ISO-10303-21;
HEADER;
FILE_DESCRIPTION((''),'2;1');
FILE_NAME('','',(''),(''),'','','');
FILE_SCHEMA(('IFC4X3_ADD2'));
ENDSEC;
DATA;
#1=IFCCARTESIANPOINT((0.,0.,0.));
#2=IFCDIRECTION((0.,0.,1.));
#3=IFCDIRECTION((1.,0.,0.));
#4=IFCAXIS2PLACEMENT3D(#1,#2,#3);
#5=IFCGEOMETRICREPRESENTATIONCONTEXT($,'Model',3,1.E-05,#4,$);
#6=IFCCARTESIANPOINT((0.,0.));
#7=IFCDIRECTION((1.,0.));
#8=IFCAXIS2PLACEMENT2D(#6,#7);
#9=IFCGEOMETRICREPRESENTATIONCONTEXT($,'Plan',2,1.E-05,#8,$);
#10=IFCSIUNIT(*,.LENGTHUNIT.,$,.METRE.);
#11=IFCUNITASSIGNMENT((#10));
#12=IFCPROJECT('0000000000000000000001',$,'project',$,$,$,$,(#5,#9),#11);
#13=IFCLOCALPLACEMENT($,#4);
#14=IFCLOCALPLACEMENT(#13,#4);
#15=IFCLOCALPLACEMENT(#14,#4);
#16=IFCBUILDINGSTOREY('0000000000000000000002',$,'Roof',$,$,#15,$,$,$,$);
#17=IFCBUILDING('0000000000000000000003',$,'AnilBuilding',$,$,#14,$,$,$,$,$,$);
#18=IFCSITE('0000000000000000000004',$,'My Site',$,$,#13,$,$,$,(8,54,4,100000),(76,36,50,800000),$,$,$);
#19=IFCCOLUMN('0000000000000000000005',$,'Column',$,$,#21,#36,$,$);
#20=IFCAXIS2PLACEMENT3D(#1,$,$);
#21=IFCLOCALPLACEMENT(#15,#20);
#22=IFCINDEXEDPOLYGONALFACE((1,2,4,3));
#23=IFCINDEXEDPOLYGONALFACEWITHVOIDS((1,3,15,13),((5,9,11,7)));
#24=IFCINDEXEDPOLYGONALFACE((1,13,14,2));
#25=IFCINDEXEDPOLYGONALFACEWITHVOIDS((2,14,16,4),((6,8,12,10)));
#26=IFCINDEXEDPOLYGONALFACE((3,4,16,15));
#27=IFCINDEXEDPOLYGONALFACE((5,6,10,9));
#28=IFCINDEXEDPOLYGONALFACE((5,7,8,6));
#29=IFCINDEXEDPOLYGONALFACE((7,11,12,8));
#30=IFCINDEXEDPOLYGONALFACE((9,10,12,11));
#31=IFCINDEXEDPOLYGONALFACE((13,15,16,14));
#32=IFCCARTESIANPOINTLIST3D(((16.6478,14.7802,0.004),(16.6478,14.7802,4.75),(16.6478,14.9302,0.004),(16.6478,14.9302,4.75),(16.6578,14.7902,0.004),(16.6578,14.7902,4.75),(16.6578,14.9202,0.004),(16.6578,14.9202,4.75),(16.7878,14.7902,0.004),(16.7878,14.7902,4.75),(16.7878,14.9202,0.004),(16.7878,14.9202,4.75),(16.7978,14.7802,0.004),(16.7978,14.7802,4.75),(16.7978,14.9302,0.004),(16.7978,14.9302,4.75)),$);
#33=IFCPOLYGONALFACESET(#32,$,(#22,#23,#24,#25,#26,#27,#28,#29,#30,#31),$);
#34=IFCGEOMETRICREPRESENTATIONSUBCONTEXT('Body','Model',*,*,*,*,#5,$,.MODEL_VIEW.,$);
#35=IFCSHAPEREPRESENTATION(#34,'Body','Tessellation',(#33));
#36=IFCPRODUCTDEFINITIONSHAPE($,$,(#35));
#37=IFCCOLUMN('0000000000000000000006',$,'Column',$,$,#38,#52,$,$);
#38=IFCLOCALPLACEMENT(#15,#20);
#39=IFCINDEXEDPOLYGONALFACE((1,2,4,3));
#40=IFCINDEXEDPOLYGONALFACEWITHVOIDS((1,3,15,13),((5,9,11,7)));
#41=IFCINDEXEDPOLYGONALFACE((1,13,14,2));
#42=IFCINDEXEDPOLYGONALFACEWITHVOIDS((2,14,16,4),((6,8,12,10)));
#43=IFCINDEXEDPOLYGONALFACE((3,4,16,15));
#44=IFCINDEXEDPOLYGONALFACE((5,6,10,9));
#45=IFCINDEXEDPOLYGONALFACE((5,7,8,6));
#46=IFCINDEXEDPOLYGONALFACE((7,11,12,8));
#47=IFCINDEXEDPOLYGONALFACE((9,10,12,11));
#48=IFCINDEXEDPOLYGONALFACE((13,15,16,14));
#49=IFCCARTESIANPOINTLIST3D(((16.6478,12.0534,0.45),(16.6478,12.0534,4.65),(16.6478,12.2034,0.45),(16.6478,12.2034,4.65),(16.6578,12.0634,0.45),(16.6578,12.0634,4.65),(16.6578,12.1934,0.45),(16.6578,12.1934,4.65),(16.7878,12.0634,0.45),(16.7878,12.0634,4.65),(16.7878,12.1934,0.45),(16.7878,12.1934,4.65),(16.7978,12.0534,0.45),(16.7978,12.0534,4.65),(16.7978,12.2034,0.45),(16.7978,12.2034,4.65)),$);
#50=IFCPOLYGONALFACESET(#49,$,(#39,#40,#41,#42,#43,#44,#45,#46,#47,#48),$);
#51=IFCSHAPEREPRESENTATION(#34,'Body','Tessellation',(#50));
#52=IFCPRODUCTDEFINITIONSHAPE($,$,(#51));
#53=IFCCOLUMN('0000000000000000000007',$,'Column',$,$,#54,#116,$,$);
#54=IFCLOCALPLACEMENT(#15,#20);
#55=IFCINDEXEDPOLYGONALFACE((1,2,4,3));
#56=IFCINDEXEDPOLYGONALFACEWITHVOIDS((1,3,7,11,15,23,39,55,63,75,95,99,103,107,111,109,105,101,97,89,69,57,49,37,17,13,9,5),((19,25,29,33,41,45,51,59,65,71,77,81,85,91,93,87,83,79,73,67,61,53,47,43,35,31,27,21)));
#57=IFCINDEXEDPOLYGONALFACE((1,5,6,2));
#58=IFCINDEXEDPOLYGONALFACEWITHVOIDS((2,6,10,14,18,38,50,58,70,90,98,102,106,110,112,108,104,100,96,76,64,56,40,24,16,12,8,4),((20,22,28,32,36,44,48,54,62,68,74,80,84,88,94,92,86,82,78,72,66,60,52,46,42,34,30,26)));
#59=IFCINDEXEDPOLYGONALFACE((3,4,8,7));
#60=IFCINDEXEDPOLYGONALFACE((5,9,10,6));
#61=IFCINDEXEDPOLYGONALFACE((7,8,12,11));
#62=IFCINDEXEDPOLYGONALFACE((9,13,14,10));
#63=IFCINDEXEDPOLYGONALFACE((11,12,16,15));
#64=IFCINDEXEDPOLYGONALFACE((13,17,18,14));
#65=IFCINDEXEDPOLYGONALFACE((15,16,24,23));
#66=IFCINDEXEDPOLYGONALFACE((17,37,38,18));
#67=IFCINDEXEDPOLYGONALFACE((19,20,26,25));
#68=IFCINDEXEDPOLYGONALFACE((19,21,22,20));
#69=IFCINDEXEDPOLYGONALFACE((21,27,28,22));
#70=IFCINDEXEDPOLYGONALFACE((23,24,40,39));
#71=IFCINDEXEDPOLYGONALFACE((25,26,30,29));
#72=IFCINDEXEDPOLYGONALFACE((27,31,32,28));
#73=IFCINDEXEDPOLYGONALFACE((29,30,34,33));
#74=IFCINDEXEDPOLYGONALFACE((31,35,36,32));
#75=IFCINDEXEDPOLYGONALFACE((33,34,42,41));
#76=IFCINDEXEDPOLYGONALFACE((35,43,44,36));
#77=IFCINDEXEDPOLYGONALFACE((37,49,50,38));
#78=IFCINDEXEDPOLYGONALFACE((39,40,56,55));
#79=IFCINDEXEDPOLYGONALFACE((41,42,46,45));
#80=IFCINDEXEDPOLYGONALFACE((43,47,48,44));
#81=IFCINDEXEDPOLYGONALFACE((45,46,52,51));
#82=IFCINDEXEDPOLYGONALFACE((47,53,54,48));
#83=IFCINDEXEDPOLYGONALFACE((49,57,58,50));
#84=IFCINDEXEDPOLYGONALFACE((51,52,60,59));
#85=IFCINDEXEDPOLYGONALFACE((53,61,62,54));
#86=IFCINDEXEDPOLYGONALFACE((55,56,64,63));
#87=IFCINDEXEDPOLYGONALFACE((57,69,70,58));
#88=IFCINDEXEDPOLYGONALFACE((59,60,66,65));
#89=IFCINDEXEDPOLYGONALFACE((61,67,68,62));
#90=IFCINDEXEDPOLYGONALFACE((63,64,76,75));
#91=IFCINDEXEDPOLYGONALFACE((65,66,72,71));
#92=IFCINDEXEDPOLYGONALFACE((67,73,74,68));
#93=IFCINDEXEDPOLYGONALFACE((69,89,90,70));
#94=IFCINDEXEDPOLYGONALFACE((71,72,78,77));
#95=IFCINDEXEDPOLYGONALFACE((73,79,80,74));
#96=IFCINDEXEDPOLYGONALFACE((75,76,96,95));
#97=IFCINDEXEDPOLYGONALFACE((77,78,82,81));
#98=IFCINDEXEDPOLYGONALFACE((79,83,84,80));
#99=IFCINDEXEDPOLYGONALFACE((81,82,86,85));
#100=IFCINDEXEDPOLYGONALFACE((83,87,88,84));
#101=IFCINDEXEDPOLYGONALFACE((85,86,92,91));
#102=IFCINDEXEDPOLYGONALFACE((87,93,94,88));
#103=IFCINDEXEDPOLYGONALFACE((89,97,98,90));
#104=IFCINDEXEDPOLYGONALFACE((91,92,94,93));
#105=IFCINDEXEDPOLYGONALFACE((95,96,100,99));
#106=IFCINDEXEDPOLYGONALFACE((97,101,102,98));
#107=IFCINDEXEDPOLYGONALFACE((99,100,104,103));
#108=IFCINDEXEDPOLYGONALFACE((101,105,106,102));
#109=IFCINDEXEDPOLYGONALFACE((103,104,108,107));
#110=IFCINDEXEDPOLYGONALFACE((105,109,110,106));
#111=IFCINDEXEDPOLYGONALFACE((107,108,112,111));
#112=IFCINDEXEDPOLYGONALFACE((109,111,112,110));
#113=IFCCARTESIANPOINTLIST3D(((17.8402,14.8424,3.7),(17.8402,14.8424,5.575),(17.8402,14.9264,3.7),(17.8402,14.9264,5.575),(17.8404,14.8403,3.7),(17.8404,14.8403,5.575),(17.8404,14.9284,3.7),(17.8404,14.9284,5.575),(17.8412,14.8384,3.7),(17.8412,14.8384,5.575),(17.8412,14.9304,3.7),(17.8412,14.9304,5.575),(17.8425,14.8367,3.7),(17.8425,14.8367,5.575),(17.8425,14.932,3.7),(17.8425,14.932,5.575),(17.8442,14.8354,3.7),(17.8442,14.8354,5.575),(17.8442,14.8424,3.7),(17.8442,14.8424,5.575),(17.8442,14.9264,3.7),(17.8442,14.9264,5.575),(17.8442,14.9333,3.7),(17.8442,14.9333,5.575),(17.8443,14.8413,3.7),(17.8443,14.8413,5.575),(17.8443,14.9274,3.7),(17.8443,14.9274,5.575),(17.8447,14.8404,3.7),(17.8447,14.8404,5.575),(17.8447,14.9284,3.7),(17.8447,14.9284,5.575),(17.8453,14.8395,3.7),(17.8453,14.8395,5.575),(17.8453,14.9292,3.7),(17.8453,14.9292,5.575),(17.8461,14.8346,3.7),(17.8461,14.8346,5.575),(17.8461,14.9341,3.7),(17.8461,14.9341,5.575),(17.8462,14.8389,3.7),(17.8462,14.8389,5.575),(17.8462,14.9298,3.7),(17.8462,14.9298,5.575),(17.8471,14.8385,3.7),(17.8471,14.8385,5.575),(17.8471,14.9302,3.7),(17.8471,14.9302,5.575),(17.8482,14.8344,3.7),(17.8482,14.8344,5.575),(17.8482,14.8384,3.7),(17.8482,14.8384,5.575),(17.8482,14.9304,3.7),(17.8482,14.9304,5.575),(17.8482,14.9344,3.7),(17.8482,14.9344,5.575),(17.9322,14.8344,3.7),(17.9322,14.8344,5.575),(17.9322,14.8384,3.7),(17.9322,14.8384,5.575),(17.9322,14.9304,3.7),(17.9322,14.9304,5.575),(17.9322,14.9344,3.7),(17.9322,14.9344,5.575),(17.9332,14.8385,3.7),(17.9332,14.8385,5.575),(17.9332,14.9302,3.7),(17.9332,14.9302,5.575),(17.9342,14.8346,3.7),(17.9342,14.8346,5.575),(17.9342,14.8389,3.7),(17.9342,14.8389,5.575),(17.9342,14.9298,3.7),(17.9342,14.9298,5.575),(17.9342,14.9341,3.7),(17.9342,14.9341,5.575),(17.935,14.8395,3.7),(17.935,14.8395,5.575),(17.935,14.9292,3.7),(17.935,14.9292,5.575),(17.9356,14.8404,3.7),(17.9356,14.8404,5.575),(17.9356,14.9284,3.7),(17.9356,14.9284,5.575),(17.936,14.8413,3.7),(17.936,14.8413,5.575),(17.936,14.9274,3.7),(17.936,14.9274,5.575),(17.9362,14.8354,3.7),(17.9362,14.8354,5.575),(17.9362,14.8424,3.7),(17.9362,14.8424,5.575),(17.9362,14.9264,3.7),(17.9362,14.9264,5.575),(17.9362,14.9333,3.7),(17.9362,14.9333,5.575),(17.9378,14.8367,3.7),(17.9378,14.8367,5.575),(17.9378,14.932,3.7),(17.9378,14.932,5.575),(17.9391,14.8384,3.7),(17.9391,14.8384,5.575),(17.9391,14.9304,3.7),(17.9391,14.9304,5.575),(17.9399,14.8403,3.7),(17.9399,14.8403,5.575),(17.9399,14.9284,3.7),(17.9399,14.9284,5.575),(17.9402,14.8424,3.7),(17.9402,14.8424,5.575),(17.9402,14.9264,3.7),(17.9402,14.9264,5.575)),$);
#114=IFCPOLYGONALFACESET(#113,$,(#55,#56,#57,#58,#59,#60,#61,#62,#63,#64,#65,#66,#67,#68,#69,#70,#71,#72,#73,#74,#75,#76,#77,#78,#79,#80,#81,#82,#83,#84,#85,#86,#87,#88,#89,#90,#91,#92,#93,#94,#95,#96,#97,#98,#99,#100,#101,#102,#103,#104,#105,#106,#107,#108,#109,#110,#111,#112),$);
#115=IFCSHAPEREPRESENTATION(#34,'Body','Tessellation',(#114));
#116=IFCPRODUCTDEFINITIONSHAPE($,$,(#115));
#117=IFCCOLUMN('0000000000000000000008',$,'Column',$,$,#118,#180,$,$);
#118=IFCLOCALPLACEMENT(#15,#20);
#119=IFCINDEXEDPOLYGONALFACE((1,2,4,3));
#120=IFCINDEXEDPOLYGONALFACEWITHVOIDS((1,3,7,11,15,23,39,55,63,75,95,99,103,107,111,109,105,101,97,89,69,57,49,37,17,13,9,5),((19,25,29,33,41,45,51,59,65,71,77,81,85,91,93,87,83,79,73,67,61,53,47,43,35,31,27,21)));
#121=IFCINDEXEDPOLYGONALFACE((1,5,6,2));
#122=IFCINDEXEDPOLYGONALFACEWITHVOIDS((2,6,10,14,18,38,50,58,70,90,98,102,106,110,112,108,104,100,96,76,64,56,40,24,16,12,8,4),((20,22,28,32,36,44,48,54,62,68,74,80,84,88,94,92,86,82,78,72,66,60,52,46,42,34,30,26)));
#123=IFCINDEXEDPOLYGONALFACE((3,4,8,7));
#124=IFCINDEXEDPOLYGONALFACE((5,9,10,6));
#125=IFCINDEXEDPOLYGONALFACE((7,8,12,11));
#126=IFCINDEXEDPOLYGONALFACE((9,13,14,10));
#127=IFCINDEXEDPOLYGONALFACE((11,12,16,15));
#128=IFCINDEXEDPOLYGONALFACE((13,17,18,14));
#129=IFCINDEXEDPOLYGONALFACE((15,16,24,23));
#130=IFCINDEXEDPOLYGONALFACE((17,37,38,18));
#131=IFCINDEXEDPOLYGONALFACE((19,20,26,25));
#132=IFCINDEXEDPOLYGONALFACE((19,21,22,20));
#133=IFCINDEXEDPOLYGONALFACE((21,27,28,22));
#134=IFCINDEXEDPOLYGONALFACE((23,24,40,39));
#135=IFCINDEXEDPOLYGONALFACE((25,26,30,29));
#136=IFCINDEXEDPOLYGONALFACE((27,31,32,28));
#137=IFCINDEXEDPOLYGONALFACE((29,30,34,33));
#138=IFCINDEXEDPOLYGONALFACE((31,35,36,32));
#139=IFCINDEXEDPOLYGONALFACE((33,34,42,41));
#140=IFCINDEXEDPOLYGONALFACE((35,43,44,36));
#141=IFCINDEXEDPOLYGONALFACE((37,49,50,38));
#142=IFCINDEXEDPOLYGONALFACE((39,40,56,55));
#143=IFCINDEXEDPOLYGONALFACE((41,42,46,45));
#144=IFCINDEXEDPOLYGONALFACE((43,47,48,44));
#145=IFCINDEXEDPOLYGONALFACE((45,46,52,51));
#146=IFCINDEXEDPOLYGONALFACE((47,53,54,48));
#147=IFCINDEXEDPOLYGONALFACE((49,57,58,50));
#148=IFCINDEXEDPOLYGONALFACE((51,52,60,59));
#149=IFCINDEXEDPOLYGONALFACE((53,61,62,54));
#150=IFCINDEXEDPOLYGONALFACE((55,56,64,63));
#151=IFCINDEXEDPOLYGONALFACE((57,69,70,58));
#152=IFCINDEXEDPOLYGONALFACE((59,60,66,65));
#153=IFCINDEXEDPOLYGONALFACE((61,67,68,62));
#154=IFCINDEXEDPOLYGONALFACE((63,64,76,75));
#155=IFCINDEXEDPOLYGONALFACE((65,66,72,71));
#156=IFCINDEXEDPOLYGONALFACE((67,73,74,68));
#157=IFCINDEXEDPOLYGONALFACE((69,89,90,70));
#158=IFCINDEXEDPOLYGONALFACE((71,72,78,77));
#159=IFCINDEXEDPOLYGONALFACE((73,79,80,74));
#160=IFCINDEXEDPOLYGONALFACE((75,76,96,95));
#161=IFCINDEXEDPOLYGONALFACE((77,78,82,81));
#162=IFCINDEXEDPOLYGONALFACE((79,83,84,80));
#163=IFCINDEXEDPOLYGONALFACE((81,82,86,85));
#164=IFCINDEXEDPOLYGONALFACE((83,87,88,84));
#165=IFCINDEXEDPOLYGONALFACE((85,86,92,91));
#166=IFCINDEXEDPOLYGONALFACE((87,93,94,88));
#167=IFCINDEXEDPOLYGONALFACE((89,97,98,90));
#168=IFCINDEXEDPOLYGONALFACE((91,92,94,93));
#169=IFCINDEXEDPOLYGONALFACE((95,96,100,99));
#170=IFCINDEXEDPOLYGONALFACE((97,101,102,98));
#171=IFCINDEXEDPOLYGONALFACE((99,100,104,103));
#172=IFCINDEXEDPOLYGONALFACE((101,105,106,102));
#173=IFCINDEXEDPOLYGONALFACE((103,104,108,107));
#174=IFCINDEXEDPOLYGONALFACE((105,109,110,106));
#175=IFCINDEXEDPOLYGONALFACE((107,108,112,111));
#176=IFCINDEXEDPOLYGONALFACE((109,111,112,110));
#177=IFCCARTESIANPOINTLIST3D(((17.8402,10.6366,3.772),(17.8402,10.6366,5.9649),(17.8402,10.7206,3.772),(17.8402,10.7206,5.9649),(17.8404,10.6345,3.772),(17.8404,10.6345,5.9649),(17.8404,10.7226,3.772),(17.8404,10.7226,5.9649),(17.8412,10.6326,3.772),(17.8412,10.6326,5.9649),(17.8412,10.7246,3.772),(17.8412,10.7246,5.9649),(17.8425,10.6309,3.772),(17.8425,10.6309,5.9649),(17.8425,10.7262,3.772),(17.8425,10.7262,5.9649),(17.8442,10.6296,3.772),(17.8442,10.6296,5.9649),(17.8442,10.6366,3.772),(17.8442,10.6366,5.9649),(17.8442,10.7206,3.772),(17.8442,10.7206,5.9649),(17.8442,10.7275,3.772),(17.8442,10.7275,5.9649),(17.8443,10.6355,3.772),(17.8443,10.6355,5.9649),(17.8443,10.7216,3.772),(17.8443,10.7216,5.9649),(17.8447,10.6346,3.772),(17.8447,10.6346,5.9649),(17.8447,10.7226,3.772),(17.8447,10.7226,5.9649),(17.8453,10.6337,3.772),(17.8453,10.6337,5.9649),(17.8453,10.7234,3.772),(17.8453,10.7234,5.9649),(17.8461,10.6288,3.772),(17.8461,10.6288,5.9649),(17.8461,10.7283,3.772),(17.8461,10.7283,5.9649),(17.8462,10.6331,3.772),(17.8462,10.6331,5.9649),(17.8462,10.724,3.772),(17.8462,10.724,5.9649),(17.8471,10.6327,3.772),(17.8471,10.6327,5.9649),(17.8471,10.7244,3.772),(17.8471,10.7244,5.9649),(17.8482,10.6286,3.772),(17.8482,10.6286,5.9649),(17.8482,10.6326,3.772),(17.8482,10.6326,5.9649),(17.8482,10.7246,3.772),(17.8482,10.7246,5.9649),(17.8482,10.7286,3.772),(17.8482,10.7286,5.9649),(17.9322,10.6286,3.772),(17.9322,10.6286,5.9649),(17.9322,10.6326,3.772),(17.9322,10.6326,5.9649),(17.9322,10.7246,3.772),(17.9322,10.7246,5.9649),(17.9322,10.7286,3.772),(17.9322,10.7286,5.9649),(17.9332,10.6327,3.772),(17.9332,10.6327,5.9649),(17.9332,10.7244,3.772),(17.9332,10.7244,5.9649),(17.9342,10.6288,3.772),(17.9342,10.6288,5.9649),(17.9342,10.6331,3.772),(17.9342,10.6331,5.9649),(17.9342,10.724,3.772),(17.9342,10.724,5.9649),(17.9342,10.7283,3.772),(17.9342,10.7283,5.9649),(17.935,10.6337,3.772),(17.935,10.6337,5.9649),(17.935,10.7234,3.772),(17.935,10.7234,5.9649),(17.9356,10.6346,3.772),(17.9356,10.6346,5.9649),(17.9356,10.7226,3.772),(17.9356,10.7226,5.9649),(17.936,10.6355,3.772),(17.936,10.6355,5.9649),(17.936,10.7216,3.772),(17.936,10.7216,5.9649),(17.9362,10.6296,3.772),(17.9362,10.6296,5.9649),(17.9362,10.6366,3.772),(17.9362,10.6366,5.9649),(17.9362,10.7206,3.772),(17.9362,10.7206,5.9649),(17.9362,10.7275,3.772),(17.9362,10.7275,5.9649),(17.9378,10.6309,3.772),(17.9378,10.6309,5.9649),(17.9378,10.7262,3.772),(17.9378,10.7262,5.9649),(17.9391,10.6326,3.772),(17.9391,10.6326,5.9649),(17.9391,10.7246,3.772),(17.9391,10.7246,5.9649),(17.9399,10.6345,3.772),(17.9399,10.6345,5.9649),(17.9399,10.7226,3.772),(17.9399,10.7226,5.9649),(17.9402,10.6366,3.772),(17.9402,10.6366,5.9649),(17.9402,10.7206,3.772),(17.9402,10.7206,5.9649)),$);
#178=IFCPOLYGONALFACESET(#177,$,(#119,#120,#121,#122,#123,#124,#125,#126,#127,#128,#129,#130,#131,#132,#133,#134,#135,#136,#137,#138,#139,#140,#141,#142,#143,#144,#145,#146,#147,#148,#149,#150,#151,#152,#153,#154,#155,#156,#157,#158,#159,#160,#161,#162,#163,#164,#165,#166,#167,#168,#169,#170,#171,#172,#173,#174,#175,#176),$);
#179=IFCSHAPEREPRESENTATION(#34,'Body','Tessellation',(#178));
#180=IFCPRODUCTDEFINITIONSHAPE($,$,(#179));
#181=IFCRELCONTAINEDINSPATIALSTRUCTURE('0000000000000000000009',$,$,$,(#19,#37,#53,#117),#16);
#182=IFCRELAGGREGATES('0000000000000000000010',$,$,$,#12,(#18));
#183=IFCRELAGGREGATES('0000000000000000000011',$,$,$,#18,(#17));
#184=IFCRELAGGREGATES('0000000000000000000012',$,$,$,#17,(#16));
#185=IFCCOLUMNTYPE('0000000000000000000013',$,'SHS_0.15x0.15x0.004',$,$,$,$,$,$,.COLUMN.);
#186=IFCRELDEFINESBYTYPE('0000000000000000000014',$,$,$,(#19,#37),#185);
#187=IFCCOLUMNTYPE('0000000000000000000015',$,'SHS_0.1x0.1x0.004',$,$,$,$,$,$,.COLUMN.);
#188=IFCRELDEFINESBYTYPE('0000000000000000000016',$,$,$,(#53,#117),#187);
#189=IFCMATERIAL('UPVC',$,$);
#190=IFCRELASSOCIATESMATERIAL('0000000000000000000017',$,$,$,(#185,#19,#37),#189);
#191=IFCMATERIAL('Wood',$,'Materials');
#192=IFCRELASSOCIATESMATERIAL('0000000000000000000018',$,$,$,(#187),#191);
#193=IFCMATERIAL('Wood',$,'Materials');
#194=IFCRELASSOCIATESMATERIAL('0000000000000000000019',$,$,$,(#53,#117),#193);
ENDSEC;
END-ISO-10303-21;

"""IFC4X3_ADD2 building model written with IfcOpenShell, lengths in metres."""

from ifc_helpers import new_model, entity, si_unit, frame, origin_with_axes, origin_2d_with_axis, place, context, subcontext, project, spatial, hollow_rectangle, extrude, shape, material, material_profile, profile_set, profile_usage, type_object, element, save


model = new_model("IFC4X3_ADD2")

# Units and contexts
model_context = context("Model", 3, precision=1e-05, world=origin_with_axes())
plan_context = context("Plan", 2, precision=1e-05, world=origin_2d_with_axis())
body_context_1 = subcontext(model_context, "Body", "Model", "MODEL_VIEW")
body_context_2 = subcontext(plan_context, "Body", "Plan", "PLAN_VIEW")
ifc_project = project(units=[si_unit("LENGTHUNIT", "METRE")], contexts=[model_context, plan_context])

# Site, building, storey
site_placement = place(None, origin_with_axes())
site = spatial("IfcSite", under=ifc_project, at=site_placement, Name="My Site", RefLatitude=(8, 54, 4, 100000), RefLongitude=(76, 36, 50, 800000))
building_placement = place(site_placement, origin_with_axes())
building = spatial("IfcBuilding", under=site, at=building_placement, Name="AnilBuilding")
storey_placement = place(building_placement, origin_with_axes())
storey = spatial("IfcBuildingStorey", under=building, at=storey_placement, Name="Roof")

# Columns
ifc_material_1 = material(Name="UPVC")
ifc_material_profile_1 = material_profile(ifc_material_1, hollow_rectangle(XDim=0.15, YDim=0.15, WallThickness=0.01))
ifc_profile_set_1 = profile_set([ifc_material_profile_1])
ifc_profile_usage_1 = profile_usage(ifc_profile_set_1, cardinal=5)
column_type_1 = type_object("IfcColumnType", Name="SHS_0.15x0.15x0.004", PredefinedType="COLUMN", material=ifc_profile_set_1)
column_1_placement = place(storey_placement, frame((16.7228, 14.8552, 0.004), z_axis=(0.0, 0.0, 1.0), x_axis=(1.0, 0.0, 0.0)))
element("IfcColumn", 1, at=column_1_placement, inside=storey, type_object=column_type_1, material=ifc_profile_usage_1, Name="Column", shapes=[
    shape(body_context_1, "Body", "SweptSolid", [extrude(hollow_rectangle(XDim=0.15, YDim=0.15, WallThickness=0.01), origin_with_axes(), (0.0, 0.0, 1.0), 4.746)]),
    shape(body_context_2, "Body", "Annotation2D", [entity("IfcGeometricCurveSet", [entity("IfcIndexedPolyCurve", entity("IfcCartesianPointList2D", [[-0.075, -0.075], [-0.075, 0.075], [0.075, 0.075], [0.075, -0.075]]), [entity("IfcLineIndex", [1, 2, 3, 4, 1])]), entity("IfcIndexedPolyCurve", entity("IfcCartesianPointList2D", [[-0.065, -0.065], [0.065, -0.065], [0.065, 0.065], [-0.065, 0.065]]), [entity("IfcLineIndex", [1, 2, 3, 4, 1])])])]),
])
ifc_profile_usage_2 = profile_usage(ifc_profile_set_1, cardinal=5)
column_2_placement = place(storey_placement, frame((16.7228, 12.1284, 0.45), z_axis=(0.0, 0.0, 1.0), x_axis=(1.0, 0.0, 0.0)))
element("IfcColumn", 2, at=column_2_placement, inside=storey, type_object=column_type_1, material=ifc_profile_usage_2, Name="Column", shapes=[
    shape(body_context_1, "Body", "SweptSolid", [extrude(hollow_rectangle(XDim=0.15, YDim=0.15, WallThickness=0.01), origin_with_axes(), (0.0, 0.0, 1.0), 4.2)]),
    shape(body_context_2, "Body", "Annotation2D", [entity("IfcGeometricCurveSet", [entity("IfcIndexedPolyCurve", entity("IfcCartesianPointList2D", [[-0.075, -0.075], [-0.075, 0.075], [0.075, 0.075], [0.075, -0.075]]), [entity("IfcLineIndex", [1, 2, 3, 4, 1])]), entity("IfcIndexedPolyCurve", entity("IfcCartesianPointList2D", [[-0.065, 0.065], [-0.065, -0.065], [0.065, -0.065], [0.065, 0.065]]), [entity("IfcLineIndex", [1, 2, 3, 4, 1])])])]),
])
ifc_material_2 = material(Name="Wood", Category="Materials")
ifc_material_profile_2 = material_profile(ifc_material_2, hollow_rectangle(XDim=0.1, YDim=0.1, WallThickness=0.004, InnerFilletRadius=0.004, OuterFilletRadius=0.008))
ifc_profile_set_2 = profile_set([ifc_material_profile_2])
column_type_2 = type_object("IfcColumnType", Name="SHS_0.1x0.1x0.004", PredefinedType="COLUMN", material=ifc_profile_set_2)
ifc_material_3 = material(Name="Wood", Category="Materials")
ifc_material_profile_3 = material_profile(ifc_material_3, hollow_rectangle(XDim=0.1, YDim=0.1, WallThickness=0.004, InnerFilletRadius=0.004, OuterFilletRadius=0.008))
ifc_profile_set_3 = profile_set([ifc_material_profile_3])
ifc_profile_usage_3 = profile_usage(ifc_profile_set_3)
column_3_placement = place(storey_placement, frame((17.8902, 14.8844, 3.7), z_axis=(0.0, 0.0, 1.0), x_axis=(0.0, -1.0, 0.0)))
element("IfcColumn", 3, at=column_3_placement, inside=storey, type_object=column_type_2, material=ifc_profile_usage_3, Name="Column", shapes=[
    shape(body_context_1, "Body", "SweptSolid", [extrude(hollow_rectangle(XDim=0.1, YDim=0.1, WallThickness=0.004, InnerFilletRadius=0.004, OuterFilletRadius=0.008), origin_with_axes(), (0.0, 0.0, 1.0), 1.875)]),
    shape(body_context_2, "Body", "Annotation2D", [entity("IfcGeometricCurveSet", [entity("IfcIndexedPolyCurve", entity("IfcCartesianPointList2D", [[0.04, -0.04], [0.04, 0.04], [-0.04, 0.04], [-0.04, -0.04]]), [entity("IfcLineIndex", [1, 2, 3, 4, 1])]), entity("IfcIndexedPolyCurve", entity("IfcCartesianPointList2D", [[-0.05, -0.05], [-0.05, 0.05], [0.05, 0.05], [0.05, -0.05]]), [entity("IfcLineIndex", [1, 2, 3, 4, 1])])])]),
])
ifc_profile_usage_4 = profile_usage(ifc_profile_set_3)
column_4_placement = place(storey_placement, frame((17.8902, 10.6786, 3.772), z_axis=(0.0, 0.0, 1.0), x_axis=(0.0, -1.0, 0.0)))
element("IfcColumn", 4, at=column_4_placement, inside=storey, type_object=column_type_2, material=ifc_profile_usage_4, Name="Column", shapes=[
    shape(body_context_1, "Body", "SweptSolid", [extrude(hollow_rectangle(XDim=0.1, YDim=0.1, WallThickness=0.004, InnerFilletRadius=0.004, OuterFilletRadius=0.008), origin_with_axes(), (0.0, 0.0, 1.0), 2.1929)]),
    shape(body_context_2, "Body", "Annotation2D", [entity("IfcGeometricCurveSet", [entity("IfcIndexedPolyCurve", entity("IfcCartesianPointList2D", [[0.04, -0.04], [0.04, 0.04], [-0.04, 0.04], [-0.04, -0.04]]), [entity("IfcLineIndex", [1, 2, 3, 4, 1])]), entity("IfcIndexedPolyCurve", entity("IfcCartesianPointList2D", [[-0.05, -0.05], [0.05, -0.05], [0.05, 0.05], [-0.05, 0.05]]), [entity("IfcLineIndex", [1, 2, 3, 4, 1])])])]),
])

save(model, "model.ifc")
